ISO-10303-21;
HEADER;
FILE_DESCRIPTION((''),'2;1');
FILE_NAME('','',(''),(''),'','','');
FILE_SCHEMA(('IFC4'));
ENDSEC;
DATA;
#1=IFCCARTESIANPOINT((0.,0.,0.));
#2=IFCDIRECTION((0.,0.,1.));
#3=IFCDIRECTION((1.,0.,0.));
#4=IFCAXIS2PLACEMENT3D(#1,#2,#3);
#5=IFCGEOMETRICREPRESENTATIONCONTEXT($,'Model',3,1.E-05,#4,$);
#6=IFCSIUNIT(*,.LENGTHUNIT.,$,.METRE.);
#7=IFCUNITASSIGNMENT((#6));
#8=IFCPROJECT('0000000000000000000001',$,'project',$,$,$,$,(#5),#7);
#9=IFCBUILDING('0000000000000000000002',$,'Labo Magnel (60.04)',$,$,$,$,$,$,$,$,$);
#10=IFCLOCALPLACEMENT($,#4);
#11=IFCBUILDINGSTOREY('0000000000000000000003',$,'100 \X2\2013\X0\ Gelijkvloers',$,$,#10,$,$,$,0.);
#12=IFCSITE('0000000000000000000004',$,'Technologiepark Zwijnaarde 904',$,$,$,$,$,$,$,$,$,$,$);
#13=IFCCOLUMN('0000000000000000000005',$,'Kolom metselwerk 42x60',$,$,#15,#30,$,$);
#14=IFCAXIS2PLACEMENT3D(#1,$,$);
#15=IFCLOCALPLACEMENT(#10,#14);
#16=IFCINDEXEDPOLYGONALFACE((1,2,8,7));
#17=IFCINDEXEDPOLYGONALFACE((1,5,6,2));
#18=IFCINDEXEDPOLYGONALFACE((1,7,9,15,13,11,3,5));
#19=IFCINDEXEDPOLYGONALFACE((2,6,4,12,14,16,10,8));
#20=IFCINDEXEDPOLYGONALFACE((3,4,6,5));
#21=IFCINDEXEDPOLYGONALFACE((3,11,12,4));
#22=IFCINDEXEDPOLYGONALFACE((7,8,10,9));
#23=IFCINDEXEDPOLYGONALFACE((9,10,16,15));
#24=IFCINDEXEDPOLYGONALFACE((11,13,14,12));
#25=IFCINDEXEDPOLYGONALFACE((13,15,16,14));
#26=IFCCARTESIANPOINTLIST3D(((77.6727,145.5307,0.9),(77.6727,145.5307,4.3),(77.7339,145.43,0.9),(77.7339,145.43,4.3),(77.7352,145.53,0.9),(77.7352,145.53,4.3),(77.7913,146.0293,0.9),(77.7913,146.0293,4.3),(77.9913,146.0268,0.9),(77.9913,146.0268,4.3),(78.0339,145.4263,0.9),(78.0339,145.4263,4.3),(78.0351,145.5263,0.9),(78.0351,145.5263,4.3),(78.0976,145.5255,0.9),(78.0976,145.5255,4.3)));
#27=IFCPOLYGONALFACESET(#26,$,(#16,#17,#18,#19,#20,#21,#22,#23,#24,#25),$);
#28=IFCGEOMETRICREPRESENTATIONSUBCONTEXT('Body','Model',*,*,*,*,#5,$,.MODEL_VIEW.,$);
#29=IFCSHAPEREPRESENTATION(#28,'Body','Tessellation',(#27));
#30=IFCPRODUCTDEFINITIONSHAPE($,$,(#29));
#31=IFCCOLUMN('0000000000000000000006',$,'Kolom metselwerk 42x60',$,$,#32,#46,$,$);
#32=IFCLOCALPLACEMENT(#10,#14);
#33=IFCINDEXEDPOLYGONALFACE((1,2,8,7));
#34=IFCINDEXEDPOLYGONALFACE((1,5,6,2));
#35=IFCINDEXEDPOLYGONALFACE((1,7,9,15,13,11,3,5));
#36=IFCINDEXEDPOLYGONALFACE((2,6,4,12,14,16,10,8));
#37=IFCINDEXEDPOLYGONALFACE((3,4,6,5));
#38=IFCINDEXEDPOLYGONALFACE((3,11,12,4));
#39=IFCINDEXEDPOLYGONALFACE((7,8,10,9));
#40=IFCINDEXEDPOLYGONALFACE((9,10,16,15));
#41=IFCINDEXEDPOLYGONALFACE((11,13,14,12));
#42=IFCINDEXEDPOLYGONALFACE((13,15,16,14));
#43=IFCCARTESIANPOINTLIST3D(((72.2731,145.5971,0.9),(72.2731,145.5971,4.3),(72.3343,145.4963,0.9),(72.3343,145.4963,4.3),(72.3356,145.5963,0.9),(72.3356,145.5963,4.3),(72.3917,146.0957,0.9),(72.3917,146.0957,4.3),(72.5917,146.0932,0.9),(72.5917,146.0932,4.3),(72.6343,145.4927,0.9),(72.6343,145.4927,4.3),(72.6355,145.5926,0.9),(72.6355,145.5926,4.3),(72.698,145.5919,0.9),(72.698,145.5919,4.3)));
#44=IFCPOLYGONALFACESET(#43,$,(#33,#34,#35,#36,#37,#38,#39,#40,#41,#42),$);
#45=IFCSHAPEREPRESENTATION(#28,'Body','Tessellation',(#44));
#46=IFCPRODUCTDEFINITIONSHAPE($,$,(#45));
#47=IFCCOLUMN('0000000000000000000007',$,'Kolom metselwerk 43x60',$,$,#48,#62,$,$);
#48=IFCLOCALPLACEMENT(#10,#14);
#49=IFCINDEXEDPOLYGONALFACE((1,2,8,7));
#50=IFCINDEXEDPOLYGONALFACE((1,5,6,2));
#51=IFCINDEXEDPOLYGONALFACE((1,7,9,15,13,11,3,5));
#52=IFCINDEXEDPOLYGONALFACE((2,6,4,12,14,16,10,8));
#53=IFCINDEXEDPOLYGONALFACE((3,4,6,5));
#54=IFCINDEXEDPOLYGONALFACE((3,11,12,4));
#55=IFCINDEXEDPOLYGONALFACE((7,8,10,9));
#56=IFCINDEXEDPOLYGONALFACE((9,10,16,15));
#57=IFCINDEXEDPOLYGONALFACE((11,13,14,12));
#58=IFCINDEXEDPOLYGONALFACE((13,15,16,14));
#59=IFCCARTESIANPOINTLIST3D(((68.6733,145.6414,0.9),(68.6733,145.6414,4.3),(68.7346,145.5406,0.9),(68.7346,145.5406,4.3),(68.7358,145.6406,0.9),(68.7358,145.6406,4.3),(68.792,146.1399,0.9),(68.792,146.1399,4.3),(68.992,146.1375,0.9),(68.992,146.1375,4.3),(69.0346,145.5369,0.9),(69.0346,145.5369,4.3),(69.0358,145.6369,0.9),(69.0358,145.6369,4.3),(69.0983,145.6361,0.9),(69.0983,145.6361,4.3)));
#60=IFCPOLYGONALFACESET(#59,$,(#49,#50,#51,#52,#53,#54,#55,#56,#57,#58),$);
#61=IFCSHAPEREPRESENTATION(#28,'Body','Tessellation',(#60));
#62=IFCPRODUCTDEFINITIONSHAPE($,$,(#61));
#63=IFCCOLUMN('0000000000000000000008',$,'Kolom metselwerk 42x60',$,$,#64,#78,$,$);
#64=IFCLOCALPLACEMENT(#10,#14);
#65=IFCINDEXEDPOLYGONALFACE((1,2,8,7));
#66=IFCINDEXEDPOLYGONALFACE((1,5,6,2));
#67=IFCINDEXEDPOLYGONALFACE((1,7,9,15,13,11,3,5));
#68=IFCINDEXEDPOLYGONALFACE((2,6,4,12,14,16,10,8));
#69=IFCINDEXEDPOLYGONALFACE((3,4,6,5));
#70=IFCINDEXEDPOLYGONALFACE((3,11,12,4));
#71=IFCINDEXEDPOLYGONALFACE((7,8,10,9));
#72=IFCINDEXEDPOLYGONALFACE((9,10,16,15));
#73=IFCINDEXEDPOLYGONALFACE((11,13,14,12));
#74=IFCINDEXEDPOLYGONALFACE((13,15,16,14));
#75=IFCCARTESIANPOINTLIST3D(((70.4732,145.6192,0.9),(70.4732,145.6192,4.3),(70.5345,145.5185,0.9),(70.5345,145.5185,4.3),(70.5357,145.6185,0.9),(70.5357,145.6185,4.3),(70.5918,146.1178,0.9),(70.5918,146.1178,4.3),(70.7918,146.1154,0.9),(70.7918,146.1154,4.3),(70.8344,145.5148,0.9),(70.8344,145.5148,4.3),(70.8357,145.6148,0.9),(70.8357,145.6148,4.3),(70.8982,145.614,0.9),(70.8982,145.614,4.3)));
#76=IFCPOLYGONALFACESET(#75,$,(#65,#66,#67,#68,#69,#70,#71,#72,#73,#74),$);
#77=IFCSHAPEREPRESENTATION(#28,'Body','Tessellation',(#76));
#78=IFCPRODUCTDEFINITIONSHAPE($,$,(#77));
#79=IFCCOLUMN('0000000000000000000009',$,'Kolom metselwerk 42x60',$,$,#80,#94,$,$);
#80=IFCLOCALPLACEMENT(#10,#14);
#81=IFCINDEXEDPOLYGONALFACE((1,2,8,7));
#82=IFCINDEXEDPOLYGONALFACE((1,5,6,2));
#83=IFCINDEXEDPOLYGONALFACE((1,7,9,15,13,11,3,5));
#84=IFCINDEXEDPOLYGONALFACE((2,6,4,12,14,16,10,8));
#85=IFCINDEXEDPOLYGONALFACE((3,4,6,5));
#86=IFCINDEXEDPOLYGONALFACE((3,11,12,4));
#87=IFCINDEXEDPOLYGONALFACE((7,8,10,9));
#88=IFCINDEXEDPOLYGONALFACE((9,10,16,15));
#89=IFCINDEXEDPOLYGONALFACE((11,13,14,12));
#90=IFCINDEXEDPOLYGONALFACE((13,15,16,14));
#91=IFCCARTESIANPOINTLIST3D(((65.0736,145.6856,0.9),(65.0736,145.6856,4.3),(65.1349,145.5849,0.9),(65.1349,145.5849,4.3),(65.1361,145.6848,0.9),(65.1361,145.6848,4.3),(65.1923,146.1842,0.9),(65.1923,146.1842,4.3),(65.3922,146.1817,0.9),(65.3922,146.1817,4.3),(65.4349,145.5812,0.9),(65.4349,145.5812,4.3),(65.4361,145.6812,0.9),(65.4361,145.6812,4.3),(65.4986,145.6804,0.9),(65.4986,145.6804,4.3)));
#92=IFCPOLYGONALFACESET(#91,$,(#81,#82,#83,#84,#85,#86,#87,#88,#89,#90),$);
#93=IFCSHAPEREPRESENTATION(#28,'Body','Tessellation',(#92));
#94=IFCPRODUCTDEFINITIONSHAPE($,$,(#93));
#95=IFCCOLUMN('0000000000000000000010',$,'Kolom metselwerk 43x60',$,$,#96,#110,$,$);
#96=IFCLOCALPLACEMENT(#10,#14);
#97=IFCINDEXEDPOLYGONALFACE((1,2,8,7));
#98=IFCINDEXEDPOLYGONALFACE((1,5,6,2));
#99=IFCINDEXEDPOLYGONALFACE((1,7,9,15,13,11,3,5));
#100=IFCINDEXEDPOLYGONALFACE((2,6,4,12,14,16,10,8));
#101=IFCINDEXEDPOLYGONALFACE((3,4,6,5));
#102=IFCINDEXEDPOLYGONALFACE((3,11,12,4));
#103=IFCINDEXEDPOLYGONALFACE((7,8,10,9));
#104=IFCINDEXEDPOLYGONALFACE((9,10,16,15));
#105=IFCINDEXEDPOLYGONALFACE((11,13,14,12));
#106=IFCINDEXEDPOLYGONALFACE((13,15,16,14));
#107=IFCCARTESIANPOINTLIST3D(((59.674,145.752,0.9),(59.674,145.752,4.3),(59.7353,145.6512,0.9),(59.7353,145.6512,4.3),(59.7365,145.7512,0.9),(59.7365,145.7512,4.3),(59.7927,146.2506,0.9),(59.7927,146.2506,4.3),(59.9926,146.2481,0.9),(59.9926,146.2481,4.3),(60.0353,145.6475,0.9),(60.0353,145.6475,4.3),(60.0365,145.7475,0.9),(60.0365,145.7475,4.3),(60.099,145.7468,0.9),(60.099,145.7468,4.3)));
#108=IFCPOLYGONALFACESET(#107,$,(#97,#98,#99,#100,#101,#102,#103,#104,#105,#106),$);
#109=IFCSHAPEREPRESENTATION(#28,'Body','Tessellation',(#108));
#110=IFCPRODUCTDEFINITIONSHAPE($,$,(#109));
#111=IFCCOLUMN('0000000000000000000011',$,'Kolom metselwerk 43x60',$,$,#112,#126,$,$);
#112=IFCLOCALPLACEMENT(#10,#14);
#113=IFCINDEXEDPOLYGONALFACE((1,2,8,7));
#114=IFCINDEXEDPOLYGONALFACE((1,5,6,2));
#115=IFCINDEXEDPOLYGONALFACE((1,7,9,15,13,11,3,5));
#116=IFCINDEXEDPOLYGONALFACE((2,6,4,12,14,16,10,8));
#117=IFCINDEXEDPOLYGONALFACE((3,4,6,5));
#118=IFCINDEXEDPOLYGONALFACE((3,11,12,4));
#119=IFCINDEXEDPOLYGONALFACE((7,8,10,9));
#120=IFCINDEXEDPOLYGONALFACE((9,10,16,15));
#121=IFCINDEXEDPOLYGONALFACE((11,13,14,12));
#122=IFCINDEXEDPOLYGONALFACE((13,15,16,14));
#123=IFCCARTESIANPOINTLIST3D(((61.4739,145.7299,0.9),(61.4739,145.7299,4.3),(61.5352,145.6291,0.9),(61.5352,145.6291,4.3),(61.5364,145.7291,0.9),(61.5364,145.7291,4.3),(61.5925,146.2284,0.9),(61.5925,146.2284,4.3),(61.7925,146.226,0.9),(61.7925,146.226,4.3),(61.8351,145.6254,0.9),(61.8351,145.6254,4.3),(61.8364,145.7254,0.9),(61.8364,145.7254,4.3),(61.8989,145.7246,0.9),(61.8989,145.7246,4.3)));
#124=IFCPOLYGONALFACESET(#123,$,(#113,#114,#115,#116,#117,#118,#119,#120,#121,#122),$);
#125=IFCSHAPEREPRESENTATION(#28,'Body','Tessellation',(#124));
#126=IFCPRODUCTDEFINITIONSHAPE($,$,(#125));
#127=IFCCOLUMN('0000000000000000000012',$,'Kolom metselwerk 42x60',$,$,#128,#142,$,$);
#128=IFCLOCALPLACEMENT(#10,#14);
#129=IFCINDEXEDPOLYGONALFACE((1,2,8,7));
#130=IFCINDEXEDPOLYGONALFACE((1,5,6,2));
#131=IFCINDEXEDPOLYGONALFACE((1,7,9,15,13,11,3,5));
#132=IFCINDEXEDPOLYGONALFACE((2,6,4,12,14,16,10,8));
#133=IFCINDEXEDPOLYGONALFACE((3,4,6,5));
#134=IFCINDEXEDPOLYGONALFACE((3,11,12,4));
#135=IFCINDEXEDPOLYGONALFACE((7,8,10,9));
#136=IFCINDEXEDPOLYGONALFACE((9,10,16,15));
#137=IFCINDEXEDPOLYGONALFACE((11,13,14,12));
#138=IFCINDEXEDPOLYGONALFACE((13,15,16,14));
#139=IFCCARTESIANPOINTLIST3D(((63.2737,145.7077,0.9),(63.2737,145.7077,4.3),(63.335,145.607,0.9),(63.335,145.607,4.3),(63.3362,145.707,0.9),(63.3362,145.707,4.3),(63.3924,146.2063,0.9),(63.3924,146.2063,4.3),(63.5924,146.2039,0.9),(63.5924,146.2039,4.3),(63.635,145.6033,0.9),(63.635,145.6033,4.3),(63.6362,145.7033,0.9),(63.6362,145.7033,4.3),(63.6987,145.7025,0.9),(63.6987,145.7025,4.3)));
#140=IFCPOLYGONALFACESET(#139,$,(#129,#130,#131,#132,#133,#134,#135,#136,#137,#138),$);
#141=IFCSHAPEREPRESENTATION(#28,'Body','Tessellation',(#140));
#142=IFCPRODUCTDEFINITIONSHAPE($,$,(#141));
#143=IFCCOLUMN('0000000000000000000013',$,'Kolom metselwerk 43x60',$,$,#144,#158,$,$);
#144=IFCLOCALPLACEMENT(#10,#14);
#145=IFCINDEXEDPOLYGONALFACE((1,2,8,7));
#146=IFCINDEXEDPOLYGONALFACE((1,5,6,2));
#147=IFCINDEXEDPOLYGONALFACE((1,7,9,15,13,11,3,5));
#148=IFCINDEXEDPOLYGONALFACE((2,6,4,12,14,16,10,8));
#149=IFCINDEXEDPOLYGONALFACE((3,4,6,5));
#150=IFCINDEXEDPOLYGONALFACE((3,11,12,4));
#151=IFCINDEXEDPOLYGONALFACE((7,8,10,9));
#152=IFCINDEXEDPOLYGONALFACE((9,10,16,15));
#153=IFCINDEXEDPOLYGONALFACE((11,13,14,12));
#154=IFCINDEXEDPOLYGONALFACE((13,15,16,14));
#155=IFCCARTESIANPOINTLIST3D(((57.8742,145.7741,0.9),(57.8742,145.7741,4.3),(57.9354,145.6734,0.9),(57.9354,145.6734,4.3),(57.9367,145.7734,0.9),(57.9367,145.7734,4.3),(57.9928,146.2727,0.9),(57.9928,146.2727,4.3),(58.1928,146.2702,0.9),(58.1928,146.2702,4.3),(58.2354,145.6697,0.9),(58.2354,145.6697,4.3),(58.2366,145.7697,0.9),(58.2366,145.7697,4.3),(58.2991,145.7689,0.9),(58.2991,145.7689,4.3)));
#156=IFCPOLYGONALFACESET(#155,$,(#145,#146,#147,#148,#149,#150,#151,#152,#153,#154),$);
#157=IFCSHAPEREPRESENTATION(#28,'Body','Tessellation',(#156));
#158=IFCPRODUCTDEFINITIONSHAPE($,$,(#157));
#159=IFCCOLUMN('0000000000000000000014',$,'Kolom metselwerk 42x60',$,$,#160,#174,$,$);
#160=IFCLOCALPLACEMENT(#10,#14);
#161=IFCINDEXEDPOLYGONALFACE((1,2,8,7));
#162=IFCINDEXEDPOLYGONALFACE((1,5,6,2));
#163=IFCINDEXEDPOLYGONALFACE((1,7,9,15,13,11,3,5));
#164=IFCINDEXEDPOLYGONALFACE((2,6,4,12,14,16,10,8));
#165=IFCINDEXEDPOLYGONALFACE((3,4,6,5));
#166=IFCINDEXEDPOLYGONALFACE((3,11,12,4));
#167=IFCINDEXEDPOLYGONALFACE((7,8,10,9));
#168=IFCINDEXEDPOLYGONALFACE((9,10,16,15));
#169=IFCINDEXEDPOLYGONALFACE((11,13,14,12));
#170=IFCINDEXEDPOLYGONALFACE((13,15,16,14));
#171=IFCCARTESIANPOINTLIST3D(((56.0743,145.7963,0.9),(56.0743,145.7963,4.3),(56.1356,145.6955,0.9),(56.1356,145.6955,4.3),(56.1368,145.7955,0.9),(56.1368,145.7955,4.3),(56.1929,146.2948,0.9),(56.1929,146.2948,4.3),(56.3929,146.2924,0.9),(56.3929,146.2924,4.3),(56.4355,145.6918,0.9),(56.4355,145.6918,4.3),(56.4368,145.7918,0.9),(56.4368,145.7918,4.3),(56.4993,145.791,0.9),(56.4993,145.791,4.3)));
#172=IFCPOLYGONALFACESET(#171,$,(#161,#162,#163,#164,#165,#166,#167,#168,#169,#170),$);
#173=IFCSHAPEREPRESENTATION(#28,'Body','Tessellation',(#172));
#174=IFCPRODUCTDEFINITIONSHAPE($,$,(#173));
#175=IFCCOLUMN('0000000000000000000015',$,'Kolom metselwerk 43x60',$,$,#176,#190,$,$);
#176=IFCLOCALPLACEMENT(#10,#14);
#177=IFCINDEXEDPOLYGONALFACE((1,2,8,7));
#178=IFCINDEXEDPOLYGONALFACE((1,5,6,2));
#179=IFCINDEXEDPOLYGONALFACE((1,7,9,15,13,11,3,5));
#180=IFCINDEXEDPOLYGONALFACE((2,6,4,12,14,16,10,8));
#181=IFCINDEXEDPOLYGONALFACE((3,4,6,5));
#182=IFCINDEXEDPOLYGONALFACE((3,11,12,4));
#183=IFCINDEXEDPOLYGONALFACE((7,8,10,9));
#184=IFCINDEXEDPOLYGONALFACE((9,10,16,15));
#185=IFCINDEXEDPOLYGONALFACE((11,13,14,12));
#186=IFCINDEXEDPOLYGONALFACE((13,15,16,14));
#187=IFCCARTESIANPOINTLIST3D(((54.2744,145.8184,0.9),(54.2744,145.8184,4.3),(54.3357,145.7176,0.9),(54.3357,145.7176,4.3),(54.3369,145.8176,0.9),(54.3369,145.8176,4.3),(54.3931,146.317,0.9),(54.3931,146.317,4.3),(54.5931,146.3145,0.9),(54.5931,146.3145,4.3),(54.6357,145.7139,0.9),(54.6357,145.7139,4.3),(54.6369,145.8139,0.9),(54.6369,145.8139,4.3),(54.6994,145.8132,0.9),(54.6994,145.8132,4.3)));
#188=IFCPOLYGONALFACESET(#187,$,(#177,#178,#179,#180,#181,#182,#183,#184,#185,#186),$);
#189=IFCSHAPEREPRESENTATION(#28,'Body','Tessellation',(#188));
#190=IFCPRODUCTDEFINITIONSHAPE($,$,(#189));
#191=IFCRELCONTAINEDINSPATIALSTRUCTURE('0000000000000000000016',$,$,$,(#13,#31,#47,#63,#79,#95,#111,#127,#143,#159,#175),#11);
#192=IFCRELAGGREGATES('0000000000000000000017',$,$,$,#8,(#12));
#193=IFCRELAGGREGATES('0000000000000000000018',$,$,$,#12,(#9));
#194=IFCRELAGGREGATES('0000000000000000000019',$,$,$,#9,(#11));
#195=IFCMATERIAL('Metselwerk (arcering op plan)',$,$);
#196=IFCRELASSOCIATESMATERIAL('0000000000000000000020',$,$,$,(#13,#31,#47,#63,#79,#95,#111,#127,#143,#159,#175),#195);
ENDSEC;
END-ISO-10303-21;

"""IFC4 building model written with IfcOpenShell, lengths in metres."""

from ifc_helpers import new_model, si_unit, frame, origin, origin_with_axes, place, context, subcontext, project, spatial, polyline, outline, extrude, material, element, save


model = new_model("IFC4")

# Units and contexts
model_context = context("Model", 3, precision=1e-05, world=origin_with_axes())
body_context = subcontext(model_context, "Body", "Model", "MODEL_VIEW")
ifc_project = project(units=[si_unit("LENGTHUNIT", "METRE")], contexts=[model_context])

# Site, building, storey
site = spatial("IfcSite", under=ifc_project, Name="Technologiepark Zwijnaarde 904")
building = spatial("IfcBuilding", under=site, Name="Labo Magnel (60.04)")
storey_placement = place(None, origin_with_axes())
storey = spatial("IfcBuildingStorey", under=building, at=storey_placement, Name="100 – Gelijkvloers", Elevation=0.0)

# Columns
ifc_material_1 = material(Name="Metselwerk (arcering op plan)")
column_1_placement = place(storey_placement, frame((0.0, 0.0, 0.9), z_axis=(0.0, 0.0, 1.0), x_axis=(1.0, 0.0, 0.0)))
element("IfcColumn", 1, at=column_1_placement, inside=storey, material=ifc_material_1, Name="Kolom metselwerk 42x60", context=body_context, shape_type="SweptSolid", body=[
    extrude(outline(polyline([(77.9913, 146.0268), (77.7913, 146.0293), (77.6727, 145.5307), (77.7352, 145.53), (77.7339, 145.43), (78.0339, 145.4263), (78.0351, 145.5263), (78.0976, 145.5255), (77.9913, 146.0268)])), origin(), (0.0, 0.0, 1.0), 3.4),
])
column_2_placement = place(storey_placement, frame((0.0, 0.0, 0.9), z_axis=(0.0, 0.0, 1.0), x_axis=(1.0, 0.0, 0.0)))
element("IfcColumn", 2, at=column_2_placement, inside=storey, material=ifc_material_1, Name="Kolom metselwerk 42x60", context=body_context, shape_type="SweptSolid", body=[
    extrude(outline(polyline([(72.6355, 145.5926), (72.698, 145.5919), (72.5917, 146.0932), (72.3917, 146.0957), (72.2731, 145.5971), (72.3356, 145.5963), (72.3343, 145.4963), (72.6343, 145.4927), (72.6355, 145.5926)])), origin(), (0.0, 0.0, 1.0), 3.4),
])
column_3_placement = place(storey_placement, frame((0.0, 0.0, 0.9), z_axis=(0.0, 0.0, 1.0), x_axis=(1.0, 0.0, 0.0)))
element("IfcColumn", 3, at=column_3_placement, inside=storey, material=ifc_material_1, Name="Kolom metselwerk 43x60", context=body_context, shape_type="SweptSolid", body=[
    extrude(outline(polyline([(68.992, 146.1375), (68.792, 146.1399), (68.6733, 145.6414), (68.7358, 145.6406), (68.7346, 145.5406), (69.0346, 145.5369), (69.0358, 145.6369), (69.0983, 145.6361), (68.992, 146.1375)])), origin(), (0.0, 0.0, 1.0), 3.4),
])
column_4_placement = place(storey_placement, frame((0.0, 0.0, 0.9), z_axis=(0.0, 0.0, 1.0), x_axis=(1.0, 0.0, 0.0)))
element("IfcColumn", 4, at=column_4_placement, inside=storey, material=ifc_material_1, Name="Kolom metselwerk 42x60", context=body_context, shape_type="SweptSolid", body=[
    extrude(outline(polyline([(70.7918, 146.1154), (70.5918, 146.1178), (70.4732, 145.6192), (70.5357, 145.6185), (70.5345, 145.5185), (70.8344, 145.5148), (70.8357, 145.6148), (70.8982, 145.614), (70.7918, 146.1154)])), origin(), (0.0, 0.0, 1.0), 3.4),
])
column_5_placement = place(storey_placement, frame((0.0, 0.0, 0.9), z_axis=(0.0, 0.0, 1.0), x_axis=(1.0, 0.0, 0.0)))
element("IfcColumn", 5, at=column_5_placement, inside=storey, material=ifc_material_1, Name="Kolom metselwerk 42x60", context=body_context, shape_type="SweptSolid", body=[
    extrude(outline(polyline([(65.3922, 146.1817), (65.1923, 146.1842), (65.0736, 145.6856), (65.1361, 145.6848), (65.1349, 145.5849), (65.4349, 145.5812), (65.4361, 145.6812), (65.4986, 145.6804), (65.3922, 146.1817)])), origin(), (0.0, 0.0, 1.0), 3.4),
])
column_6_placement = place(storey_placement, frame((0.0, 0.0, 0.9), z_axis=(0.0, 0.0, 1.0), x_axis=(1.0, 0.0, 0.0)))
element("IfcColumn", 6, at=column_6_placement, inside=storey, material=ifc_material_1, Name="Kolom metselwerk 43x60", context=body_context, shape_type="SweptSolid", body=[
    extrude(outline(polyline([(59.9926, 146.2481), (59.7927, 146.2506), (59.674, 145.752), (59.7365, 145.7512), (59.7353, 145.6512), (60.0353, 145.6475), (60.0365, 145.7475), (60.099, 145.7468), (59.9926, 146.2481)])), origin(), (0.0, 0.0, 1.0), 3.4),
])
column_7_placement = place(storey_placement, frame((0.0, 0.0, 0.9), z_axis=(0.0, 0.0, 1.0), x_axis=(1.0, 0.0, 0.0)))
element("IfcColumn", 7, at=column_7_placement, inside=storey, material=ifc_material_1, Name="Kolom metselwerk 43x60", context=body_context, shape_type="SweptSolid", body=[
    extrude(outline(polyline([(61.7925, 146.226), (61.5925, 146.2284), (61.4739, 145.7299), (61.5364, 145.7291), (61.5352, 145.6291), (61.8351, 145.6254), (61.8364, 145.7254), (61.8989, 145.7246), (61.7925, 146.226)])), origin(), (0.0, 0.0, 1.0), 3.4),
])
column_8_placement = place(storey_placement, frame((0.0, 0.0, 0.9), z_axis=(0.0, 0.0, 1.0), x_axis=(1.0, 0.0, 0.0)))
element("IfcColumn", 8, at=column_8_placement, inside=storey, material=ifc_material_1, Name="Kolom metselwerk 42x60", context=body_context, shape_type="SweptSolid", body=[
    extrude(outline(polyline([(63.5924, 146.2039), (63.3924, 146.2063), (63.2737, 145.7077), (63.3362, 145.707), (63.335, 145.607), (63.635, 145.6033), (63.6362, 145.7033), (63.6987, 145.7025), (63.5924, 146.2039)])), origin(), (0.0, 0.0, 1.0), 3.4),
])
column_9_placement = place(storey_placement, frame((0.0, 0.0, 0.9), z_axis=(0.0, 0.0, 1.0), x_axis=(1.0, 0.0, 0.0)))
element("IfcColumn", 9, at=column_9_placement, inside=storey, material=ifc_material_1, Name="Kolom metselwerk 43x60", context=body_context, shape_type="SweptSolid", body=[
    extrude(outline(polyline([(58.1928, 146.2702), (57.9928, 146.2727), (57.8742, 145.7741), (57.9367, 145.7734), (57.9354, 145.6734), (58.2354, 145.6697), (58.2366, 145.7697), (58.2991, 145.7689), (58.1928, 146.2702)])), origin(), (0.0, 0.0, 1.0), 3.4),
])
column_10_placement = place(storey_placement, frame((0.0, 0.0, 0.9), z_axis=(0.0, 0.0, 1.0), x_axis=(1.0, 0.0, 0.0)))
element("IfcColumn", 10, at=column_10_placement, inside=storey, material=ifc_material_1, Name="Kolom metselwerk 42x60", context=body_context, shape_type="SweptSolid", body=[
    extrude(outline(polyline([(56.4368, 145.7918), (56.4993, 145.791), (56.3929, 146.2924), (56.1929, 146.2948), (56.0743, 145.7963), (56.1368, 145.7955), (56.1356, 145.6955), (56.4355, 145.6918), (56.4368, 145.7918)])), origin(), (0.0, 0.0, 1.0), 3.4),
])
column_11_placement = place(storey_placement, frame((0.0, 0.0, 0.9), z_axis=(0.0, 0.0, 1.0), x_axis=(1.0, 0.0, 0.0)))
element("IfcColumn", 11, at=column_11_placement, inside=storey, material=ifc_material_1, Name="Kolom metselwerk 43x60", context=body_context, shape_type="SweptSolid", body=[
    extrude(outline(polyline([(54.5931, 146.3145), (54.3931, 146.317), (54.2744, 145.8184), (54.3369, 145.8176), (54.3357, 145.7176), (54.6357, 145.7139), (54.6369, 145.8139), (54.6994, 145.8132), (54.5931, 146.3145)])), origin(), (0.0, 0.0, 1.0), 3.4),
])

save(model, "model.ifc")
